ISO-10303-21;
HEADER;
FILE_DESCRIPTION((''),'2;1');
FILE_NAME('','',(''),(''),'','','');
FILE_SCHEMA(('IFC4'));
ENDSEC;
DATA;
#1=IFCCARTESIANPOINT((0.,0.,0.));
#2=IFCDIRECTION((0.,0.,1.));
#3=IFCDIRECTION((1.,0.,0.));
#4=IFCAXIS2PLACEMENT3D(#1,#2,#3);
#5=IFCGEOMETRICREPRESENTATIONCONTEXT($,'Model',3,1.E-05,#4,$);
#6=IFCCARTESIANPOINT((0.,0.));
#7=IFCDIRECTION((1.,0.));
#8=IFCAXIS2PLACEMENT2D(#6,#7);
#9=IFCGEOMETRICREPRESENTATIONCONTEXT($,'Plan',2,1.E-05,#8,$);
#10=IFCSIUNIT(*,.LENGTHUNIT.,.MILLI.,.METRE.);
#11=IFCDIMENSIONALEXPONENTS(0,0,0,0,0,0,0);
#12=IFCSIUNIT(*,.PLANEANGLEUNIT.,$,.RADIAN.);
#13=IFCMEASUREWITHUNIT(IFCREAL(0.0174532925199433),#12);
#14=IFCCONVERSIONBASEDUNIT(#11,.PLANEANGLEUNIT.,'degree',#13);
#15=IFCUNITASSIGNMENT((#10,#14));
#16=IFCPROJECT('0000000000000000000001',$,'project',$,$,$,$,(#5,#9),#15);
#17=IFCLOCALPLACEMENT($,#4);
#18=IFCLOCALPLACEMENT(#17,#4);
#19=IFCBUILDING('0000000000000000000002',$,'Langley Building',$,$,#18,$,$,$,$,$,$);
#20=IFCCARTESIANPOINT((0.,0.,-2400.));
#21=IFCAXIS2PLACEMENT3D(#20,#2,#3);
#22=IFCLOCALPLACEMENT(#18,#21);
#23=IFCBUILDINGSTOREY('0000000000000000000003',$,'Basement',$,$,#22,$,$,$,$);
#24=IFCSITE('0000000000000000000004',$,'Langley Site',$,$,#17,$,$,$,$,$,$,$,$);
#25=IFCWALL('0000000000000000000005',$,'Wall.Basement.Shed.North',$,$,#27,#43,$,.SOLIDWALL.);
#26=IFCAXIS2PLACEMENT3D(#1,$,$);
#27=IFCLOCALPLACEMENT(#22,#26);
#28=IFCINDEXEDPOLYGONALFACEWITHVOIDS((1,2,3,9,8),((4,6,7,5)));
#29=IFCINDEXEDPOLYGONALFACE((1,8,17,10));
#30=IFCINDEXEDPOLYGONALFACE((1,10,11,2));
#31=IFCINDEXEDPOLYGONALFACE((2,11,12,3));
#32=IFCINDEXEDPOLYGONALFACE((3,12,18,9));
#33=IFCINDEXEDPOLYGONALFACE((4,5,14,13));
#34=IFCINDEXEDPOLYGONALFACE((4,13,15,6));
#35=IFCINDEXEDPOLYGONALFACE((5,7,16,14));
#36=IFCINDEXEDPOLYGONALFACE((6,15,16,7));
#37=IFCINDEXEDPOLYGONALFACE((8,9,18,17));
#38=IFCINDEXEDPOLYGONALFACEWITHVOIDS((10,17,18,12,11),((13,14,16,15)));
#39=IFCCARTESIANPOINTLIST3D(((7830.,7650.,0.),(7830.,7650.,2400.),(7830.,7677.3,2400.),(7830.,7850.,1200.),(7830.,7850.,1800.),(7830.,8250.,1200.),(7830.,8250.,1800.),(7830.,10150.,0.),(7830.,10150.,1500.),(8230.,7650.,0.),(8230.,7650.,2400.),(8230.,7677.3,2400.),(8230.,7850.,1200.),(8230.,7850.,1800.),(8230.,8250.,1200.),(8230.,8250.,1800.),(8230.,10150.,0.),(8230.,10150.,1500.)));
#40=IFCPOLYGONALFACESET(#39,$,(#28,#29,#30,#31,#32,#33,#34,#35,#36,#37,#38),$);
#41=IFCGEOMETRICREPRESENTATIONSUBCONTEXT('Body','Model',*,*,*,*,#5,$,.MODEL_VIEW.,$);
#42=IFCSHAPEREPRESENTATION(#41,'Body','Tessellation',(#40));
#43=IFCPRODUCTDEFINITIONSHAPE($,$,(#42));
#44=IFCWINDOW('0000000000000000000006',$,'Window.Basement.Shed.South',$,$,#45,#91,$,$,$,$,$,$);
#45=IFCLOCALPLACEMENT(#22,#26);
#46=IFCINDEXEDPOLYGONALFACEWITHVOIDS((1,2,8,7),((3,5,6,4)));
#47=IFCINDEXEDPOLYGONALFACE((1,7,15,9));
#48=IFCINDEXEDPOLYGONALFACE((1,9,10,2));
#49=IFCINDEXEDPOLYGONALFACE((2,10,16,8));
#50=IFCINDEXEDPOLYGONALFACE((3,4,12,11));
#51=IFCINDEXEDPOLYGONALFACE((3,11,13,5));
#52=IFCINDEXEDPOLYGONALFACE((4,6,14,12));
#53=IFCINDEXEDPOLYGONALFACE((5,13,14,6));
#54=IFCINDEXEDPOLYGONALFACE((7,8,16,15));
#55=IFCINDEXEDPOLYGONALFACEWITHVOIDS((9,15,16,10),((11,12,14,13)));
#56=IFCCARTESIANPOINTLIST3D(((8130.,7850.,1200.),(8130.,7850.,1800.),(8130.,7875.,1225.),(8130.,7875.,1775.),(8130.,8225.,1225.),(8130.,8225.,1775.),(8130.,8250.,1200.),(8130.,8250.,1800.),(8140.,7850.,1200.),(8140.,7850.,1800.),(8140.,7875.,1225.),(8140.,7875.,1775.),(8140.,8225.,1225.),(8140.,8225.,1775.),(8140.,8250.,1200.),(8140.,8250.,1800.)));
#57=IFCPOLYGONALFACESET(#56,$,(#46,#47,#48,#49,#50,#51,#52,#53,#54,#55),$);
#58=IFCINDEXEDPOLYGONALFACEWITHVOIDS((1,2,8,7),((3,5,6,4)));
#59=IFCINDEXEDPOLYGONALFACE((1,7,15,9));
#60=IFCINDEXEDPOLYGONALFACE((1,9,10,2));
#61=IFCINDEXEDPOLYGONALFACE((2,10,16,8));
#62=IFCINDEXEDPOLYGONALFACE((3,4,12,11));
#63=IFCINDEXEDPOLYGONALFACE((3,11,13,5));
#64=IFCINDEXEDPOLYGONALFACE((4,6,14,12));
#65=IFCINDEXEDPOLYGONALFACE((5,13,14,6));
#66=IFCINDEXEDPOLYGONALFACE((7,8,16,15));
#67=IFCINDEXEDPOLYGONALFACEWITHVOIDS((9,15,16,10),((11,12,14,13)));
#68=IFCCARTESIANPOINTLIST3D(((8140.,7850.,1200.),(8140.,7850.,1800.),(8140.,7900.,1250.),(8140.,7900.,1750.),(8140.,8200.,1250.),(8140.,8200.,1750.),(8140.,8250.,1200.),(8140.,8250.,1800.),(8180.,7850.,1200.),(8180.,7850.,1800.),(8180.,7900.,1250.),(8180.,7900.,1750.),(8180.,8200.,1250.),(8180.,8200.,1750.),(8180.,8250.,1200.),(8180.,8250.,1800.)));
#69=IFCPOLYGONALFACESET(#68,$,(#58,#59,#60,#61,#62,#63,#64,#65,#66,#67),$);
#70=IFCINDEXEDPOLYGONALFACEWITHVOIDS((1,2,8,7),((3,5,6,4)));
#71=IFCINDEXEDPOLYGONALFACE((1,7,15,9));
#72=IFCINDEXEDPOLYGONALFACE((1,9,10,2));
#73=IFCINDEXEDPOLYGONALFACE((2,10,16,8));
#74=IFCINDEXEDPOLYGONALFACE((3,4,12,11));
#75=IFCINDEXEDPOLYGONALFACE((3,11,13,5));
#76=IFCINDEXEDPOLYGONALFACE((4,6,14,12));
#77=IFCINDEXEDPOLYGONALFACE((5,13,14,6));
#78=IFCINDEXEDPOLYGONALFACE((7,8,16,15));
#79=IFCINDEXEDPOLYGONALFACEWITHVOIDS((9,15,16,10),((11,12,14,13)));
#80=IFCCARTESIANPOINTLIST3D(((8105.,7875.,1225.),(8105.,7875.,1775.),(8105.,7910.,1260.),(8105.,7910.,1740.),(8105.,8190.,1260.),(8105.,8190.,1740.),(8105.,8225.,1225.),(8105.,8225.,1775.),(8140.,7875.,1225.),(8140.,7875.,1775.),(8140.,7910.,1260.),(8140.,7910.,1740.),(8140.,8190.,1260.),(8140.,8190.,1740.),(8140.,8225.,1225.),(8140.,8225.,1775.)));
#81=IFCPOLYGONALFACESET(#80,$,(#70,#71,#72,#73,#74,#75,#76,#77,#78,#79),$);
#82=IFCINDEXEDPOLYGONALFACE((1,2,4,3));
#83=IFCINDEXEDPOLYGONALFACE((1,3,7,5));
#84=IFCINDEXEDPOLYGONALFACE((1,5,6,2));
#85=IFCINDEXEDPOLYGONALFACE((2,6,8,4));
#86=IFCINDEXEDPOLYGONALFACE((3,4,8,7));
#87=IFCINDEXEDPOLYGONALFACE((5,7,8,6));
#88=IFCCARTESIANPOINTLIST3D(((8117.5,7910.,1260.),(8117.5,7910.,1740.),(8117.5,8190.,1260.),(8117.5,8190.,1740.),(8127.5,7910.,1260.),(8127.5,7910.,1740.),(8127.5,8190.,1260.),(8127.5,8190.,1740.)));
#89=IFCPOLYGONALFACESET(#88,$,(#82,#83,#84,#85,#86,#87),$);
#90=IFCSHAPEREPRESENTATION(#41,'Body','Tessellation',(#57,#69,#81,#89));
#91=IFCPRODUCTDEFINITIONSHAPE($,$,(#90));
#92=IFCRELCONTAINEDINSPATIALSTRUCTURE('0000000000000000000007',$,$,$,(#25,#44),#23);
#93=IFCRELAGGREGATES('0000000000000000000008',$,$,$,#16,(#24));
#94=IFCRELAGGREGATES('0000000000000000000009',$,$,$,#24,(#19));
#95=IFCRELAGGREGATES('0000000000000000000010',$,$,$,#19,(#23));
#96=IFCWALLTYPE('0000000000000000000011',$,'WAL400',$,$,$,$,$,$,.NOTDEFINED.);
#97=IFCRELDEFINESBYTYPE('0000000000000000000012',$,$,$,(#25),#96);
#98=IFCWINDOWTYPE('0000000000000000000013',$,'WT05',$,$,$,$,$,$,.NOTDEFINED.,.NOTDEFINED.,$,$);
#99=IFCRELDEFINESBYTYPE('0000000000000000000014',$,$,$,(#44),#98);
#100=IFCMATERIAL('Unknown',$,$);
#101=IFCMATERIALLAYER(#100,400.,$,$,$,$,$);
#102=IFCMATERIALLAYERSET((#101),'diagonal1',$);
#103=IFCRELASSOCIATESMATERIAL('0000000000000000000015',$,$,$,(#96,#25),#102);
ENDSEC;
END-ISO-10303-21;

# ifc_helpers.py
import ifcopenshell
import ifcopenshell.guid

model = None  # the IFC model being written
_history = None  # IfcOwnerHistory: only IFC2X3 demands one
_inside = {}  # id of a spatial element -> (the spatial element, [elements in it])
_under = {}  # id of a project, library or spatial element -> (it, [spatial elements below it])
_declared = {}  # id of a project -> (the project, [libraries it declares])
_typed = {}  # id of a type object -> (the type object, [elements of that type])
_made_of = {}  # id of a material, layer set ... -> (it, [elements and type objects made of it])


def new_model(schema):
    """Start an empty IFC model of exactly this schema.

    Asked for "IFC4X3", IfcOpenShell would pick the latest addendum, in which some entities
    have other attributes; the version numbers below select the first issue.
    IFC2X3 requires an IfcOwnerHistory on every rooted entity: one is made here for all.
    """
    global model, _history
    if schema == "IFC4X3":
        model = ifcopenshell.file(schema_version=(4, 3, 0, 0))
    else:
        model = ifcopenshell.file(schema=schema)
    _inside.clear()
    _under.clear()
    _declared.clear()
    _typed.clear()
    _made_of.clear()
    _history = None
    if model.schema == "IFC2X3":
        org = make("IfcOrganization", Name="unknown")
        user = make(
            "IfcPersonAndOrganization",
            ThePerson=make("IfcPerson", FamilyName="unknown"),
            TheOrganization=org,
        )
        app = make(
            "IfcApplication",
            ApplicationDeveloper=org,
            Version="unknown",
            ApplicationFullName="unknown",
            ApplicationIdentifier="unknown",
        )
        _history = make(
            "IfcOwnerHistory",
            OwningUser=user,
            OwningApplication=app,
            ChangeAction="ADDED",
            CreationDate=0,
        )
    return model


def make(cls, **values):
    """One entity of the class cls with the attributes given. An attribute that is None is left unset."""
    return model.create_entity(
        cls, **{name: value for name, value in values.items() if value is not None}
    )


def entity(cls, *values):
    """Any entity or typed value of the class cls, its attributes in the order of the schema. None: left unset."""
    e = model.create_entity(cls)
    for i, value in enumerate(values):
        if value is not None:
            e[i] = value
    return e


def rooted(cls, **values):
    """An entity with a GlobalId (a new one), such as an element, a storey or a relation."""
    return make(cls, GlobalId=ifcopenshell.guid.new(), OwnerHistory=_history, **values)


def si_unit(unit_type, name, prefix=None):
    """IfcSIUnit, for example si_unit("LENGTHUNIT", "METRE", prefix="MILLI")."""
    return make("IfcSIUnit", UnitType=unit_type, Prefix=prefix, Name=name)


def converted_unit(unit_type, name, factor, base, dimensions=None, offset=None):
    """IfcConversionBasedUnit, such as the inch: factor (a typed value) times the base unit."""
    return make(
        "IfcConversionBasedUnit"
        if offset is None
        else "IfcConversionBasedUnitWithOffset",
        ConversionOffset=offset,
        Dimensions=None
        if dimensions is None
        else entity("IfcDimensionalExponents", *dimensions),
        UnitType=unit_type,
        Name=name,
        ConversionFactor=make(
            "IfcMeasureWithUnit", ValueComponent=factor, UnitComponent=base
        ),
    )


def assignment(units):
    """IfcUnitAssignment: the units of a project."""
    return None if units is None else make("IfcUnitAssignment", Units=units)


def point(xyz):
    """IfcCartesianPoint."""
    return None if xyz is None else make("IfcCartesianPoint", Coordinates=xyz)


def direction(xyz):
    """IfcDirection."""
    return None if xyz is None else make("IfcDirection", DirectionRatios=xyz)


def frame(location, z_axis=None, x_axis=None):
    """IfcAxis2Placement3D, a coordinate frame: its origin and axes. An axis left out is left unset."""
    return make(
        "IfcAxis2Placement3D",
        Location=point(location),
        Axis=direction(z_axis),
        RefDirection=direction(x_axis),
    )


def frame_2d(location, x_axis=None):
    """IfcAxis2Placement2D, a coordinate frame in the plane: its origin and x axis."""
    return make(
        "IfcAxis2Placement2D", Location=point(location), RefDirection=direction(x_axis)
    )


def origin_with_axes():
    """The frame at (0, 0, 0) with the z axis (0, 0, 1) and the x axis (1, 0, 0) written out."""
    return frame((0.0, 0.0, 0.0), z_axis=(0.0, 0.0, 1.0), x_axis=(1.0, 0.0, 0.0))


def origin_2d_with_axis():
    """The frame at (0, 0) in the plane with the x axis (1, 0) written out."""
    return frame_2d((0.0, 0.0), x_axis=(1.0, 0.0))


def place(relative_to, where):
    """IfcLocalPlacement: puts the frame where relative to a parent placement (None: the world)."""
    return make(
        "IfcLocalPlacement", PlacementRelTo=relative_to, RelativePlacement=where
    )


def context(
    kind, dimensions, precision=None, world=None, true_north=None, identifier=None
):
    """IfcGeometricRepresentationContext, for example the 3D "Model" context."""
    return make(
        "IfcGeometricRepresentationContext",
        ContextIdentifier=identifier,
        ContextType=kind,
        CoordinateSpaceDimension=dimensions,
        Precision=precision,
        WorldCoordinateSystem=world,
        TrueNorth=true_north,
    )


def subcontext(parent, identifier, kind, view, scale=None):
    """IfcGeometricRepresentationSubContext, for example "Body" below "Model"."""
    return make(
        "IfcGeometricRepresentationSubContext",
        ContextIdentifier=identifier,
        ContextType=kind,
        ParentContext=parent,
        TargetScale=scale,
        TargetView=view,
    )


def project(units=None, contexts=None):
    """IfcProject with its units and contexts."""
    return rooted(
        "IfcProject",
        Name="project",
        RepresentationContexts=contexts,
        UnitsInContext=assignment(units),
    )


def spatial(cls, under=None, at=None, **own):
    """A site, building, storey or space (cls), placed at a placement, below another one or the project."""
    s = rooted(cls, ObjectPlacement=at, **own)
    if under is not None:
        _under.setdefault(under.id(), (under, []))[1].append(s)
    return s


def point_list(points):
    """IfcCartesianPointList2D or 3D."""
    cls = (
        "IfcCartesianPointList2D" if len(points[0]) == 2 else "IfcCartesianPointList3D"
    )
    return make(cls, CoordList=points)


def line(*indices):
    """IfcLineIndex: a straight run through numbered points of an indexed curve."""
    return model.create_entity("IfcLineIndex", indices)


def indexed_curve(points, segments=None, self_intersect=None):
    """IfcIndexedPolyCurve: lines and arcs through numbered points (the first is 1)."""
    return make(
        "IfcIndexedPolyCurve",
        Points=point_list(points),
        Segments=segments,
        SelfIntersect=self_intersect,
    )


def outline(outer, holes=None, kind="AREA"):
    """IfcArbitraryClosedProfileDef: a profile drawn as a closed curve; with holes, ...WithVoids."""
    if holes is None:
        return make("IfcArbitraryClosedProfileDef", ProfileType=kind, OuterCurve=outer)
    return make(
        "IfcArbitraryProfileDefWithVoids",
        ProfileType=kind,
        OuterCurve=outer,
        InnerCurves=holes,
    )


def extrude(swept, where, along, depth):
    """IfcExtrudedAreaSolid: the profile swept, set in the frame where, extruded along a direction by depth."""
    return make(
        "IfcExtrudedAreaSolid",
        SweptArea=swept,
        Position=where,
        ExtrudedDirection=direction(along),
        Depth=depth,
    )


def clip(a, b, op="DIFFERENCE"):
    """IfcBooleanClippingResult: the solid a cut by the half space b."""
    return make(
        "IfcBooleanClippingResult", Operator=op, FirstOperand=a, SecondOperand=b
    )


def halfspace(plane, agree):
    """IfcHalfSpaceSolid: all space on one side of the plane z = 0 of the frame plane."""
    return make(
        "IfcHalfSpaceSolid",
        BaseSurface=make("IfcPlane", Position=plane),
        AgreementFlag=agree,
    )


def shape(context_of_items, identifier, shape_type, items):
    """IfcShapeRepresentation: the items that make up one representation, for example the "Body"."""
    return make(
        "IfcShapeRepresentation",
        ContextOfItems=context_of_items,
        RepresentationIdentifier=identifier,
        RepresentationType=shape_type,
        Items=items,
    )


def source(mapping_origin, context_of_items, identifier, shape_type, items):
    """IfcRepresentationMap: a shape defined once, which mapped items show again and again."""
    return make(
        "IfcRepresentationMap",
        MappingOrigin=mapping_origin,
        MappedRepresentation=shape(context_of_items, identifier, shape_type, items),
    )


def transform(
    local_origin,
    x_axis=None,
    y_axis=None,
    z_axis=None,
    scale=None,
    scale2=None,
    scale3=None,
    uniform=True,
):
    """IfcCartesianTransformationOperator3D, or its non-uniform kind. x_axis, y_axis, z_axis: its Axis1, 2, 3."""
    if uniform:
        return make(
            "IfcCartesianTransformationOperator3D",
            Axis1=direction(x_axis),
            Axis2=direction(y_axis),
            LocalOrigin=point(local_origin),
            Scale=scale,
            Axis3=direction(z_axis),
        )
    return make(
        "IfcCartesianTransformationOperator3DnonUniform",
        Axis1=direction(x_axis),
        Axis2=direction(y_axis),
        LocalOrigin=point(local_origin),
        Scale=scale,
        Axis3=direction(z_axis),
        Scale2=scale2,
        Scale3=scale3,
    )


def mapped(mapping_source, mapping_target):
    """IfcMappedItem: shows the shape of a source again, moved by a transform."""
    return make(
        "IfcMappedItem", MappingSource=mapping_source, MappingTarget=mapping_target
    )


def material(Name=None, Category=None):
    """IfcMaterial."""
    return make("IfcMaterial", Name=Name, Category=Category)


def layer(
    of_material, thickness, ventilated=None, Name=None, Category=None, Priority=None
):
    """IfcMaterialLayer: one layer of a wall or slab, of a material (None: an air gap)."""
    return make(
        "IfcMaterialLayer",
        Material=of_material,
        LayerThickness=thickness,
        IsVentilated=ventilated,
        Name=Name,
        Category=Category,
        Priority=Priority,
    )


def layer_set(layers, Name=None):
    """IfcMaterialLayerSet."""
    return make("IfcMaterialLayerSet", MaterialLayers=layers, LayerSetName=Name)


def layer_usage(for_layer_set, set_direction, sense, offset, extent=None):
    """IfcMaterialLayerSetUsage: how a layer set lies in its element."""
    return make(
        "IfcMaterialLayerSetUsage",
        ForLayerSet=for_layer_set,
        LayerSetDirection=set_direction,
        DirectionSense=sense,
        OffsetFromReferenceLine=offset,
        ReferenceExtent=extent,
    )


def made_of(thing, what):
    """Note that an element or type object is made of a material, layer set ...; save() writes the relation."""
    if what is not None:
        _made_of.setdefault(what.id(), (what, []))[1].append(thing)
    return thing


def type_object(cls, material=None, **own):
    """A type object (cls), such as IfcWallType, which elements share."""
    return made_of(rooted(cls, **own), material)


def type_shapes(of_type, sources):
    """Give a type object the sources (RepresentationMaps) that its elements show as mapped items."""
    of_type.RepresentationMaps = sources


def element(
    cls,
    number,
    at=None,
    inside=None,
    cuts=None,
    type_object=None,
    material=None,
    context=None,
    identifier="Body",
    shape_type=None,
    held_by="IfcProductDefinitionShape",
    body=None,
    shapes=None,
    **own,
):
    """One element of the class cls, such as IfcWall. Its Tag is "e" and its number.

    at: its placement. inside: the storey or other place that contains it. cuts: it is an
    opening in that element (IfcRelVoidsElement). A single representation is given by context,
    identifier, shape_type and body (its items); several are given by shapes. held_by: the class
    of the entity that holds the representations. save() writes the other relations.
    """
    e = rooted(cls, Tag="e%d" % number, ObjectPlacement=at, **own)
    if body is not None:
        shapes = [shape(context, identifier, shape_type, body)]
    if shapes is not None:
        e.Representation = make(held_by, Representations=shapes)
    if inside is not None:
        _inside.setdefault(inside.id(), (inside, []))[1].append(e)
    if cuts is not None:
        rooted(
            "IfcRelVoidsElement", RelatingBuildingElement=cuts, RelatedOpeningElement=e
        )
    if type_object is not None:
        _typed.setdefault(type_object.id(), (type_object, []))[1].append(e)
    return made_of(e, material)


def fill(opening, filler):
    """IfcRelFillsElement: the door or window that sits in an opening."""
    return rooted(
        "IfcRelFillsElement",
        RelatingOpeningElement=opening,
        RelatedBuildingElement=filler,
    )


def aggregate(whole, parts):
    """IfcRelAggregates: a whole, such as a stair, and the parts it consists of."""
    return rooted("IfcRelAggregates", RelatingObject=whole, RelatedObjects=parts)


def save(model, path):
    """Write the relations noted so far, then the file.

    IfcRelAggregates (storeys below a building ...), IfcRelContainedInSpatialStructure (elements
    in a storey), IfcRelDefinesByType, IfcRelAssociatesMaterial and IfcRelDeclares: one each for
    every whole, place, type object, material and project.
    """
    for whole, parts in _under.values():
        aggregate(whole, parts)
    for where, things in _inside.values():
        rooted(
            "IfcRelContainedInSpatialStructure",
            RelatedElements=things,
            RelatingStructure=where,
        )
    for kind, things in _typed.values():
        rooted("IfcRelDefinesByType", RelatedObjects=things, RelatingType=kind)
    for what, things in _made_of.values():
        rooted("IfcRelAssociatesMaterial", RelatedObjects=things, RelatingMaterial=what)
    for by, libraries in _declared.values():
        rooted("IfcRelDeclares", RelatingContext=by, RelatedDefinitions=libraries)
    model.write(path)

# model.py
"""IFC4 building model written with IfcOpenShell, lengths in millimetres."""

from ifc_helpers import new_model, entity, si_unit, converted_unit, frame, origin_with_axes, origin_2d_with_axis, place, context, subcontext, project, spatial, line, indexed_curve, outline, extrude, clip, halfspace, shape, source, transform, mapped, material, layer, layer_set, layer_usage, type_object, type_shapes, element, fill, save


model = new_model("IFC4")

# Units and contexts
model_context = context("Model", 3, precision=1e-05, world=origin_with_axes())
plan_context = context("Plan", 2, precision=1e-05, world=origin_2d_with_axis())
body_context_1 = subcontext(model_context, "Body", "Model", "MODEL_VIEW")
body_context_2 = subcontext(plan_context, "Body", "Plan", "PLAN_VIEW")
ifc_project = project(units=[si_unit("LENGTHUNIT", "METRE", prefix="MILLI"), converted_unit("PLANEANGLEUNIT", "degree", entity("IfcReal", 0.0174532925199433), si_unit("PLANEANGLEUNIT", "RADIAN"), dimensions=[0, 0, 0, 0, 0, 0, 0])], contexts=[model_context, plan_context])

# Site, building, storey
site_placement = place(None, origin_with_axes())
site = spatial("IfcSite", under=ifc_project, at=site_placement, Name="Langley Site")
building_placement = place(site_placement, origin_with_axes())
building = spatial("IfcBuilding", under=site, at=building_placement, Name="Langley Building")
storey_placement = place(building_placement, frame((0.0, 0.0, -2400.0), z_axis=(0.0, 0.0, 1.0), x_axis=(1.0, 0.0, 0.0)))
storey = spatial("IfcBuildingStorey", under=building, at=storey_placement, Name="Basement")

# Shared definitions
ifc_material = material(Name="Unknown")

# Shared definitions
ifc_layer_1 = layer(ifc_material, 400.0)
ifc_layer_set_1 = layer_set([ifc_layer_1], Name="diagonal1")
wall_type_1 = type_object("IfcWallType", Name="WAL400", PredefinedType="NOTDEFINED", material=ifc_layer_set_1)

# Wall, opening, window
ifc_layer_usage_1 = layer_usage(ifc_layer_set_1, "AXIS2", "POSITIVE", 0.0)
wall_1_placement = place(storey_placement, frame((8230.0, 7650.0, 0.0), z_axis=(0.0, 0.0, 1.0), x_axis=(0.0, 1.0, 0.0)))
wall_1 = element("IfcWall", 1, at=wall_1_placement, inside=storey, type_object=wall_type_1, material=ifc_layer_usage_1, Name="Wall.Basement.Shed.North", PredefinedType="SOLIDWALL", context=body_context_1, shape_type="Clipping", body=[
    clip(extrude(outline(indexed_curve([(0.0, 0.0), (0.0, 400.0), (2500.0, 400.0), (2500.0, 0.0)], segments=[line(1, 2, 3, 4, 1)])), origin_with_axes(), (0.0, 0.0, 1.0), 2400.0), halfspace(frame((2500.0, -100.0, 1500.0), z_axis=(0.34202, 0.0, 0.939693), x_axis=(-0.939693, 0.0, 0.34202)), False)),
])
shared_shape_1 = source(origin_with_axes(), body_context_1, "Body", "SweptSolid", [
    extrude(outline(indexed_curve([(0.0, 0.0), (400.0, 0.0), (400.0, 600.0), (0.0, 600.0)], segments=[line(1, 2, 3, 4, 1)])), frame((0.0, -600.0, 0.0), z_axis=(0.0, -1.0, 0.0), x_axis=(1.0, 0.0, 0.0)), (0.0, 0.0, -1.0), 1200.0),
])
opening_1_placement = place(wall_1_placement, frame((200.0, 0.0, 1200.0), z_axis=(0.0, 0.0, 1.0), x_axis=(1.0, 0.0, 0.0)))
opening_1 = element("IfcOpeningElement", 2, at=opening_1_placement, cuts=wall_1, PredefinedType="OPENING", context=body_context_1, shape_type="MappedRepresentation", body=[
    mapped(shared_shape_1, transform((0.0, 0.0, 0.0), x_axis=(1.0, 0.0, 0.0), y_axis=(0.0, 1.0, 0.0), z_axis=(0.0, 0.0, 1.0), scale=1.0)),
])
window_type_1 = type_object("IfcWindowType", Name="WT05", PartitioningType="NOTDEFINED", PredefinedType="NOTDEFINED")
shared_shape_2 = source(origin_with_axes(), body_context_1, "Body", "SweptSolid", [
    extrude(outline(indexed_curve([(0.0, 0.0), (400.0, 0.0), (400.0, 600.0), (0.0, 600.0)], segments=[line(1, 2, 3, 4, 1)]), holes=[indexed_curve([(25.0, 25.0), (375.0, 25.0), (375.0, 575.0), (25.0, 575.0)], segments=[line(1, 2, 3, 4, 1)])]), frame((0.0, 90.0, 0.0), z_axis=(0.0, -1.0, 0.0), x_axis=(1.0, 0.0, 0.0)), (0.0, 0.0, -1.0), 10.0),
    extrude(outline(indexed_curve([(0.0, 0.0), (400.0, 0.0), (400.0, 600.0), (0.0, 600.0)], segments=[line(1, 2, 3, 4, 1)]), holes=[indexed_curve([(50.0, 50.0), (350.0, 50.0), (350.0, 550.0), (50.0, 550.0)], segments=[line(1, 2, 3, 4, 1)])]), frame((0.0, 50.0, 0.0), z_axis=(0.0, -1.0, 0.0), x_axis=(1.0, 0.0, 0.0)), (0.0, 0.0, -1.0), 40.0),
    extrude(outline(indexed_curve([(0.0, 0.0), (350.0, 0.0), (350.0, 550.0), (0.0, 550.0)], segments=[line(1, 2, 3, 4, 1)]), holes=[indexed_curve([(35.0, 35.0), (315.0, 35.0), (315.0, 515.0), (35.0, 515.0)], segments=[line(1, 2, 3, 4, 1)])]), frame((25.0, 90.0, 25.0), z_axis=(0.0, -1.0, 0.0), x_axis=(1.0, 0.0, 0.0)), (0.0, 0.0, -1.0), 35.0),
    extrude(outline(indexed_curve([(35.0, 35.0), (315.0, 35.0), (315.0, 515.0), (35.0, 515.0)], segments=[line(1, 2, 3, 4, 1)])), frame((25.0, 102.5, 25.0), z_axis=(0.0, -1.0, 0.0), x_axis=(1.0, 0.0, 0.0)), (0.0, 0.0, -1.0), 10.0),
])
shared_shape_3 = source(origin_with_axes(), body_context_2, "Body", "Curve2D", [
    entity("IfcIndexedPolyCurve", entity("IfcCartesianPointList2D", [[50.0, 50.0], [350.0, 50.0]])),
    entity("IfcIndexedPolyCurve", entity("IfcCartesianPointList2D", [[0.0, 100.0], [25.0, 100.0], [25.0, 90.0], [50.0, 90.0], [50.0, 50.0], [0.0, 50.0]]), [entity("IfcLineIndex", [1, 2, 3, 4, 5, 6, 1])]),
    entity("IfcIndexedPolyCurve", entity("IfcCartesianPointList2D", [[400.0, 100.0], [375.0, 100.0], [375.0, 90.0], [350.0, 90.0], [350.0, 50.0], [400.0, 50.0]]), [entity("IfcLineIndex", [1, 2, 3, 4, 5, 6, 1])]),
    entity("IfcIndexedPolyCurve", entity("IfcCartesianPointList2D", [[25.0, 90.0], [60.0, 90.0], [60.0, 125.0], [25.0, 125.0]]), [entity("IfcLineIndex", [1, 2, 3, 4, 1])]),
    entity("IfcIndexedPolyCurve", entity("IfcCartesianPointList2D", [[375.0, 90.0], [340.0, 90.0], [340.0, 125.0], [375.0, 125.0]]), [entity("IfcLineIndex", [1, 2, 3, 4, 1])]),
    entity("IfcIndexedPolyCurve", entity("IfcCartesianPointList2D", [[60.0, 90.0], [340.0, 90.0]])),
    entity("IfcIndexedPolyCurve", entity("IfcCartesianPointList2D", [[60.0, 125.0], [340.0, 125.0]])),
    entity("IfcIndexedPolyCurve", entity("IfcCartesianPointList2D", [[60.0, 107.5], [340.0, 107.5]])),
])
type_shapes(window_type_1, [shared_shape_2, shared_shape_3])
window_1_placement = place(opening_1_placement, frame((0.0, 0.0, 0.0), z_axis=(0.0, 0.0, 1.0), x_axis=(1.0, 0.0, 0.0)))
window_1 = element("IfcWindow", 3, at=window_1_placement, inside=storey, type_object=window_type_1, Name="Window.Basement.Shed.South", shapes=[
    shape(body_context_1, "Body", "MappedRepresentation", [mapped(shared_shape_2, transform((0.0, 0.0, 0.0), x_axis=(1.0, 0.0, 0.0), y_axis=(0.0, 1.0, 0.0), z_axis=(0.0, 0.0, 1.0), scale=1.0))]),
    shape(body_context_2, "Body", "MappedRepresentation", [mapped(shared_shape_3, transform((0.0, 0.0, 0.0), x_axis=(1.0, 0.0, 0.0), y_axis=(0.0, 1.0, 0.0), z_axis=(0.0, 0.0, 1.0), scale=1.0))]),
])
fill(opening_1, window_1)

save(model, "model.ifc")
